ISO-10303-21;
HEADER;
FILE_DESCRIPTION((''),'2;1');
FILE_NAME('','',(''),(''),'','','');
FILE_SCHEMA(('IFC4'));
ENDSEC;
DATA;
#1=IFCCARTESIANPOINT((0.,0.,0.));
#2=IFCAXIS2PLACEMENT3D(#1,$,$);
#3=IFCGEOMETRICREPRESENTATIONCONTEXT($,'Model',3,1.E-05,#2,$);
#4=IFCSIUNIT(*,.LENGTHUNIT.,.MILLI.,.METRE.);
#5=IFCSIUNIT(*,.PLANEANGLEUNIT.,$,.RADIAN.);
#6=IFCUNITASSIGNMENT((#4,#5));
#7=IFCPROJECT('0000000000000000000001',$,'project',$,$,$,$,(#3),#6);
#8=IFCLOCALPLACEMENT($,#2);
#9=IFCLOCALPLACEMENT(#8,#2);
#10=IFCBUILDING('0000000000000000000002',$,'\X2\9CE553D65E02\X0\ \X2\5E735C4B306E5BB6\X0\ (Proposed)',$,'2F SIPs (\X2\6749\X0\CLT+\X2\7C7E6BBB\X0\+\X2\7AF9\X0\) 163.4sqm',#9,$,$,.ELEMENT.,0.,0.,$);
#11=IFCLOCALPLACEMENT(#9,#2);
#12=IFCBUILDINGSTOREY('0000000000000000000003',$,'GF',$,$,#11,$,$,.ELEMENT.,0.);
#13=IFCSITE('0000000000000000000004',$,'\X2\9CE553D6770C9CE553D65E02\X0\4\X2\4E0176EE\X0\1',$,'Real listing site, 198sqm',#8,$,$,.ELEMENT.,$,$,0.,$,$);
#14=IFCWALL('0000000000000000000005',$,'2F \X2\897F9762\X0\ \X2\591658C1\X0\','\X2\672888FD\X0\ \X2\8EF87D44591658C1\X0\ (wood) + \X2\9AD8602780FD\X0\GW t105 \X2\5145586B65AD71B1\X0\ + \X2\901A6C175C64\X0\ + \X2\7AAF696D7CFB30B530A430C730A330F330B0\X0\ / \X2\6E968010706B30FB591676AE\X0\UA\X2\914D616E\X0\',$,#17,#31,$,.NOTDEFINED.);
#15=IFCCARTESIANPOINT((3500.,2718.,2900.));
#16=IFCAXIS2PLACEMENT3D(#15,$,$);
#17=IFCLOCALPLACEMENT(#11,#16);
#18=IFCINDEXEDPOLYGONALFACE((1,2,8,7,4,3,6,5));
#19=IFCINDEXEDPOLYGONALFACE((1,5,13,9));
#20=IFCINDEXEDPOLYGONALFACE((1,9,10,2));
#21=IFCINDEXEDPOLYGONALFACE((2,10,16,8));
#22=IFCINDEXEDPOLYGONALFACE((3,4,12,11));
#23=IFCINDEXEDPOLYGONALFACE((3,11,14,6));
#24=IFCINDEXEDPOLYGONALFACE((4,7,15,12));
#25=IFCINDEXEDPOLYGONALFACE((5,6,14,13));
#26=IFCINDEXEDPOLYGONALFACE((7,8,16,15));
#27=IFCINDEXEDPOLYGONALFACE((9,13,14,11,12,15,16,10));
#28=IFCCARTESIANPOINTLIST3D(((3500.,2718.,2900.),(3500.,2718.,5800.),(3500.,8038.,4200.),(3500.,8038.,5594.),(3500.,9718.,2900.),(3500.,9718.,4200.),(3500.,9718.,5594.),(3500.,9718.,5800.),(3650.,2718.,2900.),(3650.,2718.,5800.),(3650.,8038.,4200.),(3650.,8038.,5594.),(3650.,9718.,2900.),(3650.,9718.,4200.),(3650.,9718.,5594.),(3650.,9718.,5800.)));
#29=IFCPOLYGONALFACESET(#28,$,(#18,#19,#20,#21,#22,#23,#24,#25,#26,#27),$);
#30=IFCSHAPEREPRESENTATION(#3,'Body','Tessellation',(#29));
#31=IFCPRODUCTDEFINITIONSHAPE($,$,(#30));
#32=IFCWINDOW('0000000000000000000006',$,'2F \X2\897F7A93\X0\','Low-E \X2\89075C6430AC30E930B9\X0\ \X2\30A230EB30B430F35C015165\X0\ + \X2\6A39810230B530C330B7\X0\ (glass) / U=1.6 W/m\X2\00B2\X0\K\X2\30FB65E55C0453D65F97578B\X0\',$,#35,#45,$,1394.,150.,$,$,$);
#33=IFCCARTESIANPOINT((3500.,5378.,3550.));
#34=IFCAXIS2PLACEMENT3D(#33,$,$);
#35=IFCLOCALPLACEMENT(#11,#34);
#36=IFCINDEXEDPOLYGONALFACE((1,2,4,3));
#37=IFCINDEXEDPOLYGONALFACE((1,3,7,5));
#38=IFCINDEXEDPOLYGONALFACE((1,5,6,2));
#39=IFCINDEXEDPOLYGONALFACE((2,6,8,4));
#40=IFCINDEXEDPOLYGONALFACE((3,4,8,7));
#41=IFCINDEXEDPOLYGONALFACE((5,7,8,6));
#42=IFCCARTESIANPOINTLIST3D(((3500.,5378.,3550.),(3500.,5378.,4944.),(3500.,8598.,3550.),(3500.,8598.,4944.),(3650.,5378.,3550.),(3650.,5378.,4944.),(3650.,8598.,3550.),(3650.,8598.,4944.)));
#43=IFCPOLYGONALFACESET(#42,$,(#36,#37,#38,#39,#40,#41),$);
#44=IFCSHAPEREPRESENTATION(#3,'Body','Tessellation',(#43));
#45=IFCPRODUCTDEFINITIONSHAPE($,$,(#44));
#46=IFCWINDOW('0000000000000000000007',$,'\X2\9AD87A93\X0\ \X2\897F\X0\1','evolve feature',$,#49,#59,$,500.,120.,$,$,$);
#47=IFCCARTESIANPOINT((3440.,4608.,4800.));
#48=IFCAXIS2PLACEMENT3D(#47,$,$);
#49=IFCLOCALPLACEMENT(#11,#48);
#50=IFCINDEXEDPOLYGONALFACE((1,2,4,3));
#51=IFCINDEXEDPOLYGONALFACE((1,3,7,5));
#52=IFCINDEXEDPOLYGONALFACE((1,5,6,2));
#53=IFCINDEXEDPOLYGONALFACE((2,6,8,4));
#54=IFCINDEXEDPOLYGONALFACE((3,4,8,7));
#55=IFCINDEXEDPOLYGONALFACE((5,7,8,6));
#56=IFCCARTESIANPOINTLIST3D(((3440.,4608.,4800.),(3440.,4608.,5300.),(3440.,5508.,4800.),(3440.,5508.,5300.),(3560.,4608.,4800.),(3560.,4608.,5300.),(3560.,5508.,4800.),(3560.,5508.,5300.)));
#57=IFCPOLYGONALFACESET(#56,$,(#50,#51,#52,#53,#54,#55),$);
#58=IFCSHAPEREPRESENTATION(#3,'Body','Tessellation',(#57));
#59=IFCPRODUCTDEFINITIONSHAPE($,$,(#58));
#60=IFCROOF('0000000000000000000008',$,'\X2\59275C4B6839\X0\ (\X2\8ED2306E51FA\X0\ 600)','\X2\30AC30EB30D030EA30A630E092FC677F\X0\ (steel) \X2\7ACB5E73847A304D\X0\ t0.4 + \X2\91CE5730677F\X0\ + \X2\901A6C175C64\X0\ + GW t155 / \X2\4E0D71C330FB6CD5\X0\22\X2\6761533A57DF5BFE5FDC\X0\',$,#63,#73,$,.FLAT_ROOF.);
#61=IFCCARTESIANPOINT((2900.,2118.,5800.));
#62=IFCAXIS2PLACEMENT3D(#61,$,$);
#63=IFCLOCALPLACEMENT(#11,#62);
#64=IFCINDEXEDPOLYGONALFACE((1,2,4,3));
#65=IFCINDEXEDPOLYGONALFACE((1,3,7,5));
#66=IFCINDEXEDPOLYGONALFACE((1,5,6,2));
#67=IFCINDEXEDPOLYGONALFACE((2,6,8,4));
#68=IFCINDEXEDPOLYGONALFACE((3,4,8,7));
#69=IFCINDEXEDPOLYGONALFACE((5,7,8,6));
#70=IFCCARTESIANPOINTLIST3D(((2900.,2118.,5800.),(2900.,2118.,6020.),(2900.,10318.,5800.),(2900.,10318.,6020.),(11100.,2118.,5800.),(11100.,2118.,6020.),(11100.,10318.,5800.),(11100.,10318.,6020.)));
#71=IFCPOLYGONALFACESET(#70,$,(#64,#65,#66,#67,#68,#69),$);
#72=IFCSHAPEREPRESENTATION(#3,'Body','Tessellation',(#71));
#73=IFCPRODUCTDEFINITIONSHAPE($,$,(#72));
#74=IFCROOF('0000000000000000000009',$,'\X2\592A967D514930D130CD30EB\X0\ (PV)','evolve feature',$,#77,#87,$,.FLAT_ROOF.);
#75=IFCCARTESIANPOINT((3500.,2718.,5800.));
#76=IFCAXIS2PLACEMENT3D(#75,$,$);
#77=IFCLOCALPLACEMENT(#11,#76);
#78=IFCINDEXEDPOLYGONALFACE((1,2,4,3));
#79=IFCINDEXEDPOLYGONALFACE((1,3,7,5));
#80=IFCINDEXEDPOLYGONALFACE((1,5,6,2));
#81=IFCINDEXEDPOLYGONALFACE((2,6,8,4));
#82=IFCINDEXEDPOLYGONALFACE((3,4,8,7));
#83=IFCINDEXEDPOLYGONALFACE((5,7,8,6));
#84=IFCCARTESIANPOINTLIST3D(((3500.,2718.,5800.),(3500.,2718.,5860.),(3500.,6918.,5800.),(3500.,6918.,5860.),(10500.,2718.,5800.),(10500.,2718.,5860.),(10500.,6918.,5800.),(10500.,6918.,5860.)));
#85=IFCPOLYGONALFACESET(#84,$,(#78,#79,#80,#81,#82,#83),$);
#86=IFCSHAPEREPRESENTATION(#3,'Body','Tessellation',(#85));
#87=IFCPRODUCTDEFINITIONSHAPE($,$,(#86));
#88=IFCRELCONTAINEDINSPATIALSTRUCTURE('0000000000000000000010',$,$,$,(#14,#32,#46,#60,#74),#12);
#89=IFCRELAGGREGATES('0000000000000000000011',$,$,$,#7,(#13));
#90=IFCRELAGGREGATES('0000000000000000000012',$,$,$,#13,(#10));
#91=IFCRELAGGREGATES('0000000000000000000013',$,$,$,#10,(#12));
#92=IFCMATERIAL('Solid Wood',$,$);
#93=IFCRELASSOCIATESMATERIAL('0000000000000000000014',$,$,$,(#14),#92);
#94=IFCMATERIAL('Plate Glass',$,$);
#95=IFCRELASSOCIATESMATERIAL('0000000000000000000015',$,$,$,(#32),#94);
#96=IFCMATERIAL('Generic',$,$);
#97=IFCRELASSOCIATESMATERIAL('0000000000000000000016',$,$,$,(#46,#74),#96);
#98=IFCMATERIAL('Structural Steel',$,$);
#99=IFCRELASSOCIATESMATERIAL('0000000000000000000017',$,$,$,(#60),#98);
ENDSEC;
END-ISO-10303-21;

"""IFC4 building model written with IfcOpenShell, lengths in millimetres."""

from ifc_helpers import new_model, si_unit, frame, frame_2d, origin, place, context, project, spatial, rectangle, extrude, material, element, fill, save


model = new_model("IFC4")

# Units and contexts
model_context = context("Model", 3, precision=1e-05, world=origin())
ifc_project = project(units=[si_unit("LENGTHUNIT", "METRE", prefix="MILLI"), si_unit("PLANEANGLEUNIT", "RADIAN")], contexts=[model_context])

# Site, building, storey
site_placement = place(None, origin())
site = spatial("IfcSite", under=ifc_project, at=site_placement, Name="鳥取県鳥取市4丁目1", ObjectType="Real listing site, 198sqm", CompositionType="ELEMENT", RefElevation=0.0)
building_placement = place(site_placement, origin())
building = spatial("IfcBuilding", under=site, at=building_placement, Name="鳥取市 平屋の家 (Proposed)", ObjectType="2F SIPs (杉CLT+籾殻+竹) 163.4sqm", CompositionType="ELEMENT", ElevationOfRefHeight=0.0, ElevationOfTerrain=0.0)
storey_placement = place(building_placement, origin())
storey = spatial("IfcBuildingStorey", under=building, at=storey_placement, Name="GF", CompositionType="ELEMENT", Elevation=0.0)

# Shared definitions
ifc_material_1 = material(Name="Solid Wood")
ifc_material_2 = material(Name="Generic")

# Shared definitions
ifc_material_3 = material(Name="Plate Glass")

# Wall, openings, windows
wall_1_placement = place(storey_placement, frame((3500.0, 2718.0, 2900.0)))
wall_1 = element("IfcWall", 1, at=wall_1_placement, inside=storey, material=ifc_material_1, Name="2F 西面 外壁", Description="木製 軸組外壁 (wood) + 高性能GW t105 充填断熱 + 通気層 + 窯業系サイディング / 準耐火・外皮UA配慮", PredefinedType="NOTDEFINED", context=model_context, shape_type="SweptSolid", body=[
    extrude(rectangle(XDim=150.0, YDim=7000.0, at=frame_2d((75.0, 3500.0))), frame((3500.0, 2718.0, 2900.0)), (0.0, 0.0, 1.0), 2900.0),
])
opening_1_placement = place(storey_placement, frame((3500.0, 5378.0, 3550.0)))
opening_1 = element("IfcOpeningElement", 2, at=opening_1_placement, cuts=wall_1, PredefinedType="NOTDEFINED", context=model_context, shape_type="SweptSolid", body=[
    extrude(rectangle(XDim=150.0, YDim=3220.0, at=frame_2d((75.0, 1610.0))), frame((3500.0, 5378.0, 3550.0)), (0.0, 0.0, 1.0), 1394.0),
])
opening_2_placement = place(storey_placement, frame((3440.0, 4608.0, 4800.0)))
opening_2 = element("IfcOpeningElement", 3, at=opening_2_placement, cuts=wall_1, PredefinedType="NOTDEFINED", context=model_context, shape_type="SweptSolid", body=[
    extrude(rectangle(XDim=120.0, YDim=900.0, at=frame_2d((60.0, 450.0))), frame((3440.0, 4608.0, 4800.0)), (0.0, 0.0, 1.0), 500.0),
])
window_1_placement = place(storey_placement, frame((3500.0, 5378.0, 3550.0)))
window_1 = element("IfcWindow", 4, at=window_1_placement, inside=storey, material=ifc_material_3, Name="2F 西窓", Description="Low-E 複層ガラス アルゴン封入 + 樹脂サッシ (glass) / U=1.6 W/m²K・日射取得型", OverallHeight=1394.0, OverallWidth=150.0, context=model_context, shape_type="SweptSolid", body=[
    extrude(rectangle(XDim=150.0, YDim=3220.0, at=frame_2d((75.0, 1610.0))), frame((3500.0, 5378.0, 3550.0)), (0.0, 0.0, 1.0), 1394.0),
])
fill(opening_1, window_1)
window_2_placement = place(storey_placement, frame((3440.0, 4608.0, 4800.0)))
window_2 = element("IfcWindow", 5, at=window_2_placement, inside=storey, material=ifc_material_2, Name="高窓 西1", Description="evolve feature", OverallHeight=500.0, OverallWidth=120.0, context=model_context, shape_type="SweptSolid", body=[
    extrude(rectangle(XDim=120.0, YDim=900.0, at=frame_2d((60.0, 450.0))), frame((3440.0, 4608.0, 4800.0)), (0.0, 0.0, 1.0), 500.0),
])
fill(opening_2, window_2)

# Roofs
ifc_material_4 = material(Name="Structural Steel")
roof_1_placement = place(storey_placement, frame((2900.0, 2118.0, 5800.0)))
element("IfcRoof", 6, at=roof_1_placement, inside=storey, material=ifc_material_4, Name="大屋根 (軒の出 600)", Description="ガルバリウム鋼板 (steel) 立平葺き t0.4 + 野地板 + 通気層 + GW t155 / 不燃・法22条区域対応", PredefinedType="FLAT_ROOF", context=model_context, shape_type="SweptSolid", body=[
    extrude(rectangle(XDim=8200.0, YDim=8200.0, at=frame_2d((4100.0, 4100.0))), frame((2900.0, 2118.0, 5800.0)), (0.0, 0.0, 1.0), 220.0),
])
roof_2_placement = place(storey_placement, frame((3500.0, 2718.0, 5800.0)))
element("IfcRoof", 7, at=roof_2_placement, inside=storey, material=ifc_material_2, Name="太陽光パネル (PV)", Description="evolve feature", PredefinedType="FLAT_ROOF", context=model_context, shape_type="SweptSolid", body=[
    extrude(rectangle(XDim=7000.0, YDim=4200.0, at=frame_2d((3500.0, 2100.0))), frame((3500.0, 2718.0, 5800.0)), (0.0, 0.0, 1.0), 60.0),
])

save(model, "model.ifc")
